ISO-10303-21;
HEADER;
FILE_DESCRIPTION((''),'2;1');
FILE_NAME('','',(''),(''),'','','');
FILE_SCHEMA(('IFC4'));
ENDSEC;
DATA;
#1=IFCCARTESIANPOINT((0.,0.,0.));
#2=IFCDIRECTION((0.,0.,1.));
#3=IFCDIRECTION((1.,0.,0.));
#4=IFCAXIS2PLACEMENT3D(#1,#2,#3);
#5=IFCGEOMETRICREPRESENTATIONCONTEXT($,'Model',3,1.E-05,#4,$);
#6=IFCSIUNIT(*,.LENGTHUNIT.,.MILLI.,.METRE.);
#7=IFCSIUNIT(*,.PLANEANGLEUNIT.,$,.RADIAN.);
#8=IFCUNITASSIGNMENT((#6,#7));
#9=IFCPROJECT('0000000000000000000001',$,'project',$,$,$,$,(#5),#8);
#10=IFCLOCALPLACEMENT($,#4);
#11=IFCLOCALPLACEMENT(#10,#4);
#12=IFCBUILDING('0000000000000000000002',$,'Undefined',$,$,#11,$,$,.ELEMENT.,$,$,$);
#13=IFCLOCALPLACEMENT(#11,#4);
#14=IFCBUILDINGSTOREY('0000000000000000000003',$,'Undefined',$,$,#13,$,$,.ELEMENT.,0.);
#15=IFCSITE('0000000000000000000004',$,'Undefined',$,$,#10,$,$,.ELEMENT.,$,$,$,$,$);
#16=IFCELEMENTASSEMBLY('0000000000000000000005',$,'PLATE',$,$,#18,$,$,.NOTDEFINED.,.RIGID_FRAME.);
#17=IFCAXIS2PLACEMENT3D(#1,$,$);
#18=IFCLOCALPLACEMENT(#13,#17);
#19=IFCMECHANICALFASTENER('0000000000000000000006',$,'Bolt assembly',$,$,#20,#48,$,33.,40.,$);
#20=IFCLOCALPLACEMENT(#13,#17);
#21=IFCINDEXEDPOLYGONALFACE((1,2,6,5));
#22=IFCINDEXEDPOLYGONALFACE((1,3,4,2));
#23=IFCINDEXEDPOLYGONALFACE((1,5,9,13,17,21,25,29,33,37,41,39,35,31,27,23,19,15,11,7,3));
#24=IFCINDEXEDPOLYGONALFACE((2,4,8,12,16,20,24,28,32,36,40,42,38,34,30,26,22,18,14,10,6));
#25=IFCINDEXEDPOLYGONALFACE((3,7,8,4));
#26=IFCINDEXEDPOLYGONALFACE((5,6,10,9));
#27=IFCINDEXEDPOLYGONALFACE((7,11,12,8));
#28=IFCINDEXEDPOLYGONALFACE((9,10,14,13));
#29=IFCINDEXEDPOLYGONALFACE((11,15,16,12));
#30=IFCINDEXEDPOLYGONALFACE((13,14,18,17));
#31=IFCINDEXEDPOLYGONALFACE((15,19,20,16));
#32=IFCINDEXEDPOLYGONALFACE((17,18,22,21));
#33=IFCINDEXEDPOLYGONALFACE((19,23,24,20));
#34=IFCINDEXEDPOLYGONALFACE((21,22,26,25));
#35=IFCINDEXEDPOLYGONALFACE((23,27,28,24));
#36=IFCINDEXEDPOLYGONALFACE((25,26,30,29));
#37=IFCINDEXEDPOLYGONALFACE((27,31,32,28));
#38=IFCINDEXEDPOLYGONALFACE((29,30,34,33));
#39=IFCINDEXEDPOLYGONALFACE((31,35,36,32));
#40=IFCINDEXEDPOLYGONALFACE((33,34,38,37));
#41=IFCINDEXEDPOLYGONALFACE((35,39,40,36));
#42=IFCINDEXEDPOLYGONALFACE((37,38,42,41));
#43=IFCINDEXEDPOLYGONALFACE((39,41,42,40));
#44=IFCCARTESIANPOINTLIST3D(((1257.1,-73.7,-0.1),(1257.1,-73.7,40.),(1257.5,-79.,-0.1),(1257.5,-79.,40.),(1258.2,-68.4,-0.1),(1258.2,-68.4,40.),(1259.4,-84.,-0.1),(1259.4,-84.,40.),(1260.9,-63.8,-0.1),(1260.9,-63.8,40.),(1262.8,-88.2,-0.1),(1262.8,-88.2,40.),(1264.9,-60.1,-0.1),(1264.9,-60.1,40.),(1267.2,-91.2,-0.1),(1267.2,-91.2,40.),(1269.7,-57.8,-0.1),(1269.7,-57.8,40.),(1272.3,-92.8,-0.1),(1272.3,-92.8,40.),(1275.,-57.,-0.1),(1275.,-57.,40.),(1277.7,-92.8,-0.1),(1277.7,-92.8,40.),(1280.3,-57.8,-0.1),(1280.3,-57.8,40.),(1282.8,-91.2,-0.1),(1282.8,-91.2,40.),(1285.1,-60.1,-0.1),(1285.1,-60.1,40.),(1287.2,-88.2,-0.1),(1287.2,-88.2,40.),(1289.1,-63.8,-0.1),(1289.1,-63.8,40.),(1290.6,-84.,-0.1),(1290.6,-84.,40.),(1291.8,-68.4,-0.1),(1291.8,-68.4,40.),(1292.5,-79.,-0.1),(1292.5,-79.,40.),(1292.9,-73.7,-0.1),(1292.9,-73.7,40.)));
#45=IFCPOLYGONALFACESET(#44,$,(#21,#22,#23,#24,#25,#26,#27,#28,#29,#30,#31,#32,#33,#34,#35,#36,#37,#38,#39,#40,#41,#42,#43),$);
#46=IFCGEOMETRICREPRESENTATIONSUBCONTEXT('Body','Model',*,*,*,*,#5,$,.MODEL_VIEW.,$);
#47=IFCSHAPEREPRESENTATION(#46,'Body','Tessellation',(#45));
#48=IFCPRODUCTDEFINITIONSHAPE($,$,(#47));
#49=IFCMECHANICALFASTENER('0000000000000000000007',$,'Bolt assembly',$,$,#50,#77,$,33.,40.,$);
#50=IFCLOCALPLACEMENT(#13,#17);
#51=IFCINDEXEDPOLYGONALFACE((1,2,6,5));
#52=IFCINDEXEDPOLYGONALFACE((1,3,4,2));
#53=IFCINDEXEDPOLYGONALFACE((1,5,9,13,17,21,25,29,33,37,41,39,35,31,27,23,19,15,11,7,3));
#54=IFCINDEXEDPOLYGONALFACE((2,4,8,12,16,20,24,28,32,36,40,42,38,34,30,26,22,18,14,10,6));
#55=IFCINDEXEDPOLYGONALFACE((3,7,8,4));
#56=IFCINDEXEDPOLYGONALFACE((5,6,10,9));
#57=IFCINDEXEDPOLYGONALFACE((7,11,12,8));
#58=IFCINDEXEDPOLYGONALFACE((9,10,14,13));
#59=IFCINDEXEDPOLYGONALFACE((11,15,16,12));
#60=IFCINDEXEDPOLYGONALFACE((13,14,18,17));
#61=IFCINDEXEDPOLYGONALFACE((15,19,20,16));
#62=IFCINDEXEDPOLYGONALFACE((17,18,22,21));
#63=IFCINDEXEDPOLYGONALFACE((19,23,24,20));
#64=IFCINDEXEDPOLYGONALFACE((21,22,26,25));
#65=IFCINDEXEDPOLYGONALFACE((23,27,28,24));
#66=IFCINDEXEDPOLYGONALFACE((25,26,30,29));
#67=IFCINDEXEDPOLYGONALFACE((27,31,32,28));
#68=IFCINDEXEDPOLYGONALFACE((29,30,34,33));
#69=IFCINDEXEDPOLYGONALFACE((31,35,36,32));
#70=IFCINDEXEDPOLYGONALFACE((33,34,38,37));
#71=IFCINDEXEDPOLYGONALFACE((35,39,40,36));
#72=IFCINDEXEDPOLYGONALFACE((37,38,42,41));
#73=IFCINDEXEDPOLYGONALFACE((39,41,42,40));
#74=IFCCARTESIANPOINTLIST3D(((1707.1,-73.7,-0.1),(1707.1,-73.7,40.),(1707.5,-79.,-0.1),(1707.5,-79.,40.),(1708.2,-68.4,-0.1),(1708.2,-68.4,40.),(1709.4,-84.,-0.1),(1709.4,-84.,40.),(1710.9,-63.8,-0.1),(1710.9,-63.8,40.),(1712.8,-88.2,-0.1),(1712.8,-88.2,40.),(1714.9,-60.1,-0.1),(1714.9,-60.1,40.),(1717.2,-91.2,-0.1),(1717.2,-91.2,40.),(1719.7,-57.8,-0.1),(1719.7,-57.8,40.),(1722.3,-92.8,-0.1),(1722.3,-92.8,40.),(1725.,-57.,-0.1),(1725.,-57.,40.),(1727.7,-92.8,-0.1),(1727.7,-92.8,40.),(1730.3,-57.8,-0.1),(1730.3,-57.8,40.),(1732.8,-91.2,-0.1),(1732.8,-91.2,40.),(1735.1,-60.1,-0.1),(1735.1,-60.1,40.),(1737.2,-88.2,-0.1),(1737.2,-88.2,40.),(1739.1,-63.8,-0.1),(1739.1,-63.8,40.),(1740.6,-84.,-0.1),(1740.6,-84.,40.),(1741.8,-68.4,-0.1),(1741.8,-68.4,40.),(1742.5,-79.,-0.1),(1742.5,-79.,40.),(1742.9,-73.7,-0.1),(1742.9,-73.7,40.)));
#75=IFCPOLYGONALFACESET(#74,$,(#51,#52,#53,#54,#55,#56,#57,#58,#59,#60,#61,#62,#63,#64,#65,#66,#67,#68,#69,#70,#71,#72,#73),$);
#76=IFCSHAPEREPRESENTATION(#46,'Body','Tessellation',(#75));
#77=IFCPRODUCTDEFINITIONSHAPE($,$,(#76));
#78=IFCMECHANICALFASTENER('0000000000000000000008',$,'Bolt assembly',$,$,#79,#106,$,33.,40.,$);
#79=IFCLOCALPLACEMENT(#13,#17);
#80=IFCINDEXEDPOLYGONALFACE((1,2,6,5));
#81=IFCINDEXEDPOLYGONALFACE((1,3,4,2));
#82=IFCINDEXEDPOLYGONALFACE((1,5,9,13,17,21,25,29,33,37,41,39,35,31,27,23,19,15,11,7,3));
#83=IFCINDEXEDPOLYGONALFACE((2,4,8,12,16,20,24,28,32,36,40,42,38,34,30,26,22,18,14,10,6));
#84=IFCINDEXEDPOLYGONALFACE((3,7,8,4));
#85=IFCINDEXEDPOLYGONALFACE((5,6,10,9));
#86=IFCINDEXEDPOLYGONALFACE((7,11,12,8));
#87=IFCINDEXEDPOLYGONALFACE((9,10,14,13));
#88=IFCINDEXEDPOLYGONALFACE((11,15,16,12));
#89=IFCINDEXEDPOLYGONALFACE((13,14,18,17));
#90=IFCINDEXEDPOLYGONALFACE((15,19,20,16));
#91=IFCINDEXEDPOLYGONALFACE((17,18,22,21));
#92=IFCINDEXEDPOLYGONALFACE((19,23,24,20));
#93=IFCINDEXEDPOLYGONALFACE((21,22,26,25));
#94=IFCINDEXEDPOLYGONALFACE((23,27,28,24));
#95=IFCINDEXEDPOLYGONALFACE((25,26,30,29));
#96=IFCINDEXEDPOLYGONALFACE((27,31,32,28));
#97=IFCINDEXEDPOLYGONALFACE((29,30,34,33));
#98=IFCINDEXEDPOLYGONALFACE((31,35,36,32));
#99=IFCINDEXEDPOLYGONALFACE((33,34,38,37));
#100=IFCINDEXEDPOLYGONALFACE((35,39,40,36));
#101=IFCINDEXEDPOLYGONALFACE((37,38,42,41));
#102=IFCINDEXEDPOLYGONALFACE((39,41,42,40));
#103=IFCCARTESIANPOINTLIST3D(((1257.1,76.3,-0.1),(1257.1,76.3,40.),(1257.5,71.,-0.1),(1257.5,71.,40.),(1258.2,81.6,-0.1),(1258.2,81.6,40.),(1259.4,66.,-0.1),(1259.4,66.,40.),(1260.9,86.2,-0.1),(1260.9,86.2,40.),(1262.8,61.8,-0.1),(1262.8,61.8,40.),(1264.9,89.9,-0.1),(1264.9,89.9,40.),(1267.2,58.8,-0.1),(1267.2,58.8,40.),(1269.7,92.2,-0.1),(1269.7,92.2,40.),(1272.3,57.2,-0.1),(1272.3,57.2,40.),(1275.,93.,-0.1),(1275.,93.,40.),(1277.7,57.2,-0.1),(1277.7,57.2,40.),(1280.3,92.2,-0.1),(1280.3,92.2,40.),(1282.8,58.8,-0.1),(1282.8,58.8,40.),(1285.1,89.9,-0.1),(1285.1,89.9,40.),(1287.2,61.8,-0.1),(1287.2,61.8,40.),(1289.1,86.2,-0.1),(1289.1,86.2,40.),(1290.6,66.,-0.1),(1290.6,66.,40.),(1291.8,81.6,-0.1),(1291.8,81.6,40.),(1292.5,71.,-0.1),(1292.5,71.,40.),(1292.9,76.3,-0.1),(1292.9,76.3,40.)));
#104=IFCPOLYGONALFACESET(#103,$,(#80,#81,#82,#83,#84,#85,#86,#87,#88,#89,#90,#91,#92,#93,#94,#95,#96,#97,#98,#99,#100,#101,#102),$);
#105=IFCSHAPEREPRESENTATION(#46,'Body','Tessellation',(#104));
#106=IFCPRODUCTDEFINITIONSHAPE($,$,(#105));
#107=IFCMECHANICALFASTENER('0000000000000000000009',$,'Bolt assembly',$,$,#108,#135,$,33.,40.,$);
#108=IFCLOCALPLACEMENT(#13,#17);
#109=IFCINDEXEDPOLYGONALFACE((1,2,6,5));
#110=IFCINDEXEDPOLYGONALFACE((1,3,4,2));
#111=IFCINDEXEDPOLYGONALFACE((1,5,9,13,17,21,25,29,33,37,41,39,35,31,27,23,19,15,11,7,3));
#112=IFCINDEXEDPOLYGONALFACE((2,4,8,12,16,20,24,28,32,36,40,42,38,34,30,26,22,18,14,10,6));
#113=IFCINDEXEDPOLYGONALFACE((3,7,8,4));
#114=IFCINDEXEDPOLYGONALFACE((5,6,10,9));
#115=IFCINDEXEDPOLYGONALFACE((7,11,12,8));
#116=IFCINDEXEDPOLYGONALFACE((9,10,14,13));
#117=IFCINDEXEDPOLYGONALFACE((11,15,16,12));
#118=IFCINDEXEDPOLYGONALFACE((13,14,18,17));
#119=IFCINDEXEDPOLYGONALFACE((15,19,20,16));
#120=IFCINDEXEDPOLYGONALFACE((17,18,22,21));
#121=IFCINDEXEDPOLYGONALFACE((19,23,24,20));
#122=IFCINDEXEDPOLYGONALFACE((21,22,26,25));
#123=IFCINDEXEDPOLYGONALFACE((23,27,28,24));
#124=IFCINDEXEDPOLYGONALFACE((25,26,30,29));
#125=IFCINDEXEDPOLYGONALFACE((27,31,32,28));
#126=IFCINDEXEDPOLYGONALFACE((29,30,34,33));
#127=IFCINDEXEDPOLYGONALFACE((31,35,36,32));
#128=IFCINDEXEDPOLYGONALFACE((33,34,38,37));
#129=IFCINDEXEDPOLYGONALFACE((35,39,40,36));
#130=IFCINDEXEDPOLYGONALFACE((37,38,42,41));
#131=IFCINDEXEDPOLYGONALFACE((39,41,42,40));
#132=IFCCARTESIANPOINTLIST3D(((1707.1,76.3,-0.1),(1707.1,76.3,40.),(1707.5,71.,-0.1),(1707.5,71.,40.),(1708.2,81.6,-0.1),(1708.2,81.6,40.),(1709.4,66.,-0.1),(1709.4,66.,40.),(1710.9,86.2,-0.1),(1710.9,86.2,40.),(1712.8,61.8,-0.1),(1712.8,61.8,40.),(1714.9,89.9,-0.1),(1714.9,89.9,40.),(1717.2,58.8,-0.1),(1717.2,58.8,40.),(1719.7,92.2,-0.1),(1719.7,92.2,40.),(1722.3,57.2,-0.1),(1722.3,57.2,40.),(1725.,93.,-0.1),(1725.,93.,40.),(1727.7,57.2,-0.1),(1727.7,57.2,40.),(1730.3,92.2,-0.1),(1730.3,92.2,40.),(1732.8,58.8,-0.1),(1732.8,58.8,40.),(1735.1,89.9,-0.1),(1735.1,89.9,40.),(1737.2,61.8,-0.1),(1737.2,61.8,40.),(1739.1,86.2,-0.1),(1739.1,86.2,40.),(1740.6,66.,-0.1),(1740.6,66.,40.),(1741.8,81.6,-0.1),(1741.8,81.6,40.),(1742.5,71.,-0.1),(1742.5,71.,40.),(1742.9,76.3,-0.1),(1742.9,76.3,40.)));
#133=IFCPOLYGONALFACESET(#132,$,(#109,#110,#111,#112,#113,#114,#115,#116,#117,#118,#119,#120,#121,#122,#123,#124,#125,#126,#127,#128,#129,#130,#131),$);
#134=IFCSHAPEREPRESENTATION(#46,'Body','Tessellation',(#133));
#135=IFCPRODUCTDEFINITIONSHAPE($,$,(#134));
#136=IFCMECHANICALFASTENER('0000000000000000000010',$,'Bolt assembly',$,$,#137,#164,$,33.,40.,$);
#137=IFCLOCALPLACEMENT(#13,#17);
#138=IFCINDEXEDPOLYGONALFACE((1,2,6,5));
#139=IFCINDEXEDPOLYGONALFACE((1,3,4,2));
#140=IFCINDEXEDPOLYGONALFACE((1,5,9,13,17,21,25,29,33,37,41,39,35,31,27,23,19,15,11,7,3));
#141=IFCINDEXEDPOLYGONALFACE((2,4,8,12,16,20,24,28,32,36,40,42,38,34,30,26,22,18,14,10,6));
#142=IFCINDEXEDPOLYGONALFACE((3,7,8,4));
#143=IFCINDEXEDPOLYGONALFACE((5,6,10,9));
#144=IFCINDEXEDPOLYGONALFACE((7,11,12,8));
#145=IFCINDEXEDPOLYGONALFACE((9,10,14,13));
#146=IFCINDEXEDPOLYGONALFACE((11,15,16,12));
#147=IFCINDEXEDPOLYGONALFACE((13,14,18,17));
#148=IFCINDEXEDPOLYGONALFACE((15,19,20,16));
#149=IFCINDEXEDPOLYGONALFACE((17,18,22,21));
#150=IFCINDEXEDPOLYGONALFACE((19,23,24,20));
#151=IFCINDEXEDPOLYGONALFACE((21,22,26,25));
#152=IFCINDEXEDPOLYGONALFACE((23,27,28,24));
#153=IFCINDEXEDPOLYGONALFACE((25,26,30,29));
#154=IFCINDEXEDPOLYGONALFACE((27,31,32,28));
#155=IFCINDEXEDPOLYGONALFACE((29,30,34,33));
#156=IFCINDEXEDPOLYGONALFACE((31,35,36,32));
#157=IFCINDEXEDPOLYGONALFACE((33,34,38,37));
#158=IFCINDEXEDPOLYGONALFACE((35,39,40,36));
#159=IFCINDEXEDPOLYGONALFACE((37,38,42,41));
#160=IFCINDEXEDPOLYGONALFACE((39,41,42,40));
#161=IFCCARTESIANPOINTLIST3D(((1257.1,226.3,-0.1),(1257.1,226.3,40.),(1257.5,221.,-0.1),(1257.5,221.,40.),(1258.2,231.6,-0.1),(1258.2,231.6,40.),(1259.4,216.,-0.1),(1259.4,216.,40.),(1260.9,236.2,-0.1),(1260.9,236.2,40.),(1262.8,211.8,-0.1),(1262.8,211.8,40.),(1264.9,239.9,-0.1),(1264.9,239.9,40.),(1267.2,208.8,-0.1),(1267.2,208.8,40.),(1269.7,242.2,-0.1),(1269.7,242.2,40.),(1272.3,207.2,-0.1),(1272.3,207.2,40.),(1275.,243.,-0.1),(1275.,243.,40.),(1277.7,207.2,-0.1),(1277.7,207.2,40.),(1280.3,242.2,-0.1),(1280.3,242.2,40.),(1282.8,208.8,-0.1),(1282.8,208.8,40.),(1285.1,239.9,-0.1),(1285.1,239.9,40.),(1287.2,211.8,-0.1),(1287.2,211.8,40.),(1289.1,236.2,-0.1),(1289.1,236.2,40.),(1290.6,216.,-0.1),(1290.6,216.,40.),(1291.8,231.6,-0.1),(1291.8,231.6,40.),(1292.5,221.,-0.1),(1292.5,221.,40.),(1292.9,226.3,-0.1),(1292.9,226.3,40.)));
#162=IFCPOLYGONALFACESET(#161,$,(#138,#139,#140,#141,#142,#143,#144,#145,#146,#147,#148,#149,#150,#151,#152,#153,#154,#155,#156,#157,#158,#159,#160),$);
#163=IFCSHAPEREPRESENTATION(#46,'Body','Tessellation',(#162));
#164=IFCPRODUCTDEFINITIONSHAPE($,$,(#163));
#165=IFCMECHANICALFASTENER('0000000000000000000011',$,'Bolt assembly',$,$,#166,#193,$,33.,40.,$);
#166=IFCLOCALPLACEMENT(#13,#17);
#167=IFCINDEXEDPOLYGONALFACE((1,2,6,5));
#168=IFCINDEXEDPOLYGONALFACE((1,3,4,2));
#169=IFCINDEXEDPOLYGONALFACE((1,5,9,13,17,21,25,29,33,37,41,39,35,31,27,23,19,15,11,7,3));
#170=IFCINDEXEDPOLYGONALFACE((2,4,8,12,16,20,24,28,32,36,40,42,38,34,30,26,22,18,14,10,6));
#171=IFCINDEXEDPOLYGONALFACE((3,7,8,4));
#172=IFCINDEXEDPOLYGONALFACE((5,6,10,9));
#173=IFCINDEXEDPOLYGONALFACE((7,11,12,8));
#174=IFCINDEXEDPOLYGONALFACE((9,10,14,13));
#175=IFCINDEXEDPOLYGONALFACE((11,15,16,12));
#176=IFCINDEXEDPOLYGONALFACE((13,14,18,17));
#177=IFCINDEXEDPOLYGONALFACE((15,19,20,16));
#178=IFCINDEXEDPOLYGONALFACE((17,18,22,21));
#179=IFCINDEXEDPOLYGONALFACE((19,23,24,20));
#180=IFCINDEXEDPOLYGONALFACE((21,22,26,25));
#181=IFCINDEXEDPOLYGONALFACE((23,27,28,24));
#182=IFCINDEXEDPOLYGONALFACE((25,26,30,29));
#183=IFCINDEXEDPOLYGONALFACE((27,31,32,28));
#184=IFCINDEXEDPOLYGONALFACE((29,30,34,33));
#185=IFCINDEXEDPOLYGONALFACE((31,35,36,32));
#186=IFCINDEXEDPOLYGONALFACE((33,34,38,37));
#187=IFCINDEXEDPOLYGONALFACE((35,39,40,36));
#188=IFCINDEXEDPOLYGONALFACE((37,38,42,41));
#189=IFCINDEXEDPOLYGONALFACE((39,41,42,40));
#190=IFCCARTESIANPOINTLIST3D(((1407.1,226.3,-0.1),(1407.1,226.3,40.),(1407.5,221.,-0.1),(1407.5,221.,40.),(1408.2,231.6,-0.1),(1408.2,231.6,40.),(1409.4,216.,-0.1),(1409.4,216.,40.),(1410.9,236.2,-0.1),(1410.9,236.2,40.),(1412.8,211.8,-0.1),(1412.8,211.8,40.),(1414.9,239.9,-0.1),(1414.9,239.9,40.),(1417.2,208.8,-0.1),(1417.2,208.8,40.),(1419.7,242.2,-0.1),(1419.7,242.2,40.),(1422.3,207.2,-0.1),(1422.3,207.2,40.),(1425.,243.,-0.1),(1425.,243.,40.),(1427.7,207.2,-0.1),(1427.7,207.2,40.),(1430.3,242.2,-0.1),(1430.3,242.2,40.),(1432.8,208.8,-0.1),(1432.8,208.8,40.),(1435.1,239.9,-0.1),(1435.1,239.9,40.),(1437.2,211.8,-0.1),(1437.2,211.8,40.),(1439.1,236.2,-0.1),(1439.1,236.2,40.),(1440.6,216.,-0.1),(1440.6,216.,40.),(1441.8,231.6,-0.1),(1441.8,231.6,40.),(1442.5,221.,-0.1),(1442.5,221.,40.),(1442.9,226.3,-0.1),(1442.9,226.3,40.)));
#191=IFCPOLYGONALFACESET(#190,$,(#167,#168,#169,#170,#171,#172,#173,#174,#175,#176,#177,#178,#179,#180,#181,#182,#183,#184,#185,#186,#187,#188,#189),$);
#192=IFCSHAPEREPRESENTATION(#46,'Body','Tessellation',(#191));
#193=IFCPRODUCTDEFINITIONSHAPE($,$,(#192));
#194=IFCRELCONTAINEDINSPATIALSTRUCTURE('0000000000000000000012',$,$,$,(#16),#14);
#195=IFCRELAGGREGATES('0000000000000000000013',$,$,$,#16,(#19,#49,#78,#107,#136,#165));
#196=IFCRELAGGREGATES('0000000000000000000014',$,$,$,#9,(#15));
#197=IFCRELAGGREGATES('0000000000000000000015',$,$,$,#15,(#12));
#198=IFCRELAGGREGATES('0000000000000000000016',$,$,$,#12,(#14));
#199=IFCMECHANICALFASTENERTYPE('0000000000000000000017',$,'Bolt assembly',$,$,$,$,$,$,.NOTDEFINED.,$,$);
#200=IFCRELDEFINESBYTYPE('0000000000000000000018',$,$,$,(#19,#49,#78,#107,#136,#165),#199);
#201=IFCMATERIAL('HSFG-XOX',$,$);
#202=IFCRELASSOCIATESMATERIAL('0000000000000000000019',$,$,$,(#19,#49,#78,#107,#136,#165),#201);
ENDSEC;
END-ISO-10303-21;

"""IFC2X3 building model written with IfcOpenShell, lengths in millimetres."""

from ifc_helpers import new_model, si_unit, frame, origin_with_axes, origin_2d_with_axis, place, context, subcontext, project, spatial, circle, extrude, source, transform, mapped, material, type_object, element, aggregate, save


model = new_model("IFC2X3")

# Units and contexts
model_context = context("Model", 3, precision=1e-05, world=origin_with_axes())
body_context = subcontext(model_context, "Body", "Model", "MODEL_VIEW")
ifc_project = project(units=[si_unit("LENGTHUNIT", "METRE", prefix="MILLI"), si_unit("PLANEANGLEUNIT", "RADIAN")], contexts=[model_context])

# Site, building, storey
site_placement = place(None, origin_with_axes())
site = spatial("IfcSite", under=ifc_project, at=site_placement, Name="Undefined", CompositionType="ELEMENT")
building_placement = place(site_placement, origin_with_axes())
building = spatial("IfcBuilding", under=site, at=building_placement, Name="Undefined", CompositionType="ELEMENT")
storey_placement = place(building_placement, origin_with_axes())
storey = spatial("IfcBuildingStorey", under=building, at=storey_placement, Name="Undefined", CompositionType="ELEMENT", Elevation=0.0)

# Element assembly, mechanical fasteners
assembly_1_placement = place(storey_placement, origin_with_axes())
assembly_1 = element("IfcElementAssembly", 1, at=assembly_1_placement, inside=storey, Name="PLATE", AssemblyPlace="NOTDEFINED", PredefinedType="RIGID_FRAME")
ifc_material_1 = material(Name="HSFG-XOX")
mechanical_fastener_type = type_object("IfcMechanicalFastenerType", Name="Bolt assembly")
shared_shape = source(origin_with_axes(), body_context, "Body", "SweptSolid", [
    extrude(circle(Radius=18.0, at=origin_2d_with_axis()), frame((0.0, -40.0, 0.0), z_axis=(0.0, 1.0, 0.0), x_axis=(1.0, 0.0, 0.0)), (0.0, 0.0, 1.0), 40.1),
])
mechanical_fastener_1_placement = place(assembly_1_placement, frame((1275.0, -75.0, 0.0), z_axis=(-1.0, 0.0, 0.0), x_axis=(0.0, 1.0, 0.0)))
mechanical_fastener_1 = element("IfcMechanicalFastener", 2, at=mechanical_fastener_1_placement, type_object=mechanical_fastener_type, material=ifc_material_1, Name="Bolt assembly", NominalDiameter=33.0, NominalLength=40.0, context=body_context, shape_type="MappedRepresentation", body=[
    mapped(shared_shape, transform((0.0, 0.0, 0.0))),
])
mechanical_fastener_2_placement = place(assembly_1_placement, frame((1725.0, -75.0, 0.0), z_axis=(-1.0, 0.0, 0.0), x_axis=(0.0, 1.0, 0.0)))
mechanical_fastener_2 = element("IfcMechanicalFastener", 3, at=mechanical_fastener_2_placement, type_object=mechanical_fastener_type, material=ifc_material_1, Name="Bolt assembly", NominalDiameter=33.0, NominalLength=40.0, context=body_context, shape_type="MappedRepresentation", body=[
    mapped(shared_shape, transform((0.0, 0.0, 0.0))),
])
mechanical_fastener_3_placement = place(assembly_1_placement, frame((1275.0, 75.0, 0.0), z_axis=(-1.0, 0.0, 0.0), x_axis=(0.0, 1.0, 0.0)))
mechanical_fastener_3 = element("IfcMechanicalFastener", 4, at=mechanical_fastener_3_placement, type_object=mechanical_fastener_type, material=ifc_material_1, Name="Bolt assembly", NominalDiameter=33.0, NominalLength=40.0, context=body_context, shape_type="MappedRepresentation", body=[
    mapped(shared_shape, transform((0.0, 0.0, 0.0))),
])
mechanical_fastener_4_placement = place(assembly_1_placement, frame((1725.0, 75.0, 0.0), z_axis=(-1.0, 0.0, 0.0), x_axis=(0.0, 1.0, 0.0)))
mechanical_fastener_4 = element("IfcMechanicalFastener", 5, at=mechanical_fastener_4_placement, type_object=mechanical_fastener_type, material=ifc_material_1, Name="Bolt assembly", NominalDiameter=33.0, NominalLength=40.0, context=body_context, shape_type="MappedRepresentation", body=[
    mapped(shared_shape, transform((0.0, 0.0, 0.0))),
])
mechanical_fastener_5_placement = place(assembly_1_placement, frame((1275.0, 225.0, 0.0), z_axis=(-1.0, 0.0, 0.0), x_axis=(0.0, 1.0, 0.0)))
mechanical_fastener_5 = element("IfcMechanicalFastener", 6, at=mechanical_fastener_5_placement, type_object=mechanical_fastener_type, material=ifc_material_1, Name="Bolt assembly", NominalDiameter=33.0, NominalLength=40.0, context=body_context, shape_type="MappedRepresentation", body=[
    mapped(shared_shape, transform((0.0, 0.0, 0.0))),
])
mechanical_fastener_6_placement = place(assembly_1_placement, frame((1425.0, 225.0, 0.0), z_axis=(-1.0, 0.0, 0.0), x_axis=(0.0, 1.0, 0.0)))
mechanical_fastener_6 = element("IfcMechanicalFastener", 7, at=mechanical_fastener_6_placement, type_object=mechanical_fastener_type, material=ifc_material_1, Name="Bolt assembly", NominalDiameter=33.0, NominalLength=40.0, context=body_context, shape_type="MappedRepresentation", body=[
    mapped(shared_shape, transform((0.0, 0.0, 0.0))),
])
aggregate(assembly_1, [mechanical_fastener_1, mechanical_fastener_2, mechanical_fastener_3, mechanical_fastener_4, mechanical_fastener_5, mechanical_fastener_6])

save(model, "model.ifc")
